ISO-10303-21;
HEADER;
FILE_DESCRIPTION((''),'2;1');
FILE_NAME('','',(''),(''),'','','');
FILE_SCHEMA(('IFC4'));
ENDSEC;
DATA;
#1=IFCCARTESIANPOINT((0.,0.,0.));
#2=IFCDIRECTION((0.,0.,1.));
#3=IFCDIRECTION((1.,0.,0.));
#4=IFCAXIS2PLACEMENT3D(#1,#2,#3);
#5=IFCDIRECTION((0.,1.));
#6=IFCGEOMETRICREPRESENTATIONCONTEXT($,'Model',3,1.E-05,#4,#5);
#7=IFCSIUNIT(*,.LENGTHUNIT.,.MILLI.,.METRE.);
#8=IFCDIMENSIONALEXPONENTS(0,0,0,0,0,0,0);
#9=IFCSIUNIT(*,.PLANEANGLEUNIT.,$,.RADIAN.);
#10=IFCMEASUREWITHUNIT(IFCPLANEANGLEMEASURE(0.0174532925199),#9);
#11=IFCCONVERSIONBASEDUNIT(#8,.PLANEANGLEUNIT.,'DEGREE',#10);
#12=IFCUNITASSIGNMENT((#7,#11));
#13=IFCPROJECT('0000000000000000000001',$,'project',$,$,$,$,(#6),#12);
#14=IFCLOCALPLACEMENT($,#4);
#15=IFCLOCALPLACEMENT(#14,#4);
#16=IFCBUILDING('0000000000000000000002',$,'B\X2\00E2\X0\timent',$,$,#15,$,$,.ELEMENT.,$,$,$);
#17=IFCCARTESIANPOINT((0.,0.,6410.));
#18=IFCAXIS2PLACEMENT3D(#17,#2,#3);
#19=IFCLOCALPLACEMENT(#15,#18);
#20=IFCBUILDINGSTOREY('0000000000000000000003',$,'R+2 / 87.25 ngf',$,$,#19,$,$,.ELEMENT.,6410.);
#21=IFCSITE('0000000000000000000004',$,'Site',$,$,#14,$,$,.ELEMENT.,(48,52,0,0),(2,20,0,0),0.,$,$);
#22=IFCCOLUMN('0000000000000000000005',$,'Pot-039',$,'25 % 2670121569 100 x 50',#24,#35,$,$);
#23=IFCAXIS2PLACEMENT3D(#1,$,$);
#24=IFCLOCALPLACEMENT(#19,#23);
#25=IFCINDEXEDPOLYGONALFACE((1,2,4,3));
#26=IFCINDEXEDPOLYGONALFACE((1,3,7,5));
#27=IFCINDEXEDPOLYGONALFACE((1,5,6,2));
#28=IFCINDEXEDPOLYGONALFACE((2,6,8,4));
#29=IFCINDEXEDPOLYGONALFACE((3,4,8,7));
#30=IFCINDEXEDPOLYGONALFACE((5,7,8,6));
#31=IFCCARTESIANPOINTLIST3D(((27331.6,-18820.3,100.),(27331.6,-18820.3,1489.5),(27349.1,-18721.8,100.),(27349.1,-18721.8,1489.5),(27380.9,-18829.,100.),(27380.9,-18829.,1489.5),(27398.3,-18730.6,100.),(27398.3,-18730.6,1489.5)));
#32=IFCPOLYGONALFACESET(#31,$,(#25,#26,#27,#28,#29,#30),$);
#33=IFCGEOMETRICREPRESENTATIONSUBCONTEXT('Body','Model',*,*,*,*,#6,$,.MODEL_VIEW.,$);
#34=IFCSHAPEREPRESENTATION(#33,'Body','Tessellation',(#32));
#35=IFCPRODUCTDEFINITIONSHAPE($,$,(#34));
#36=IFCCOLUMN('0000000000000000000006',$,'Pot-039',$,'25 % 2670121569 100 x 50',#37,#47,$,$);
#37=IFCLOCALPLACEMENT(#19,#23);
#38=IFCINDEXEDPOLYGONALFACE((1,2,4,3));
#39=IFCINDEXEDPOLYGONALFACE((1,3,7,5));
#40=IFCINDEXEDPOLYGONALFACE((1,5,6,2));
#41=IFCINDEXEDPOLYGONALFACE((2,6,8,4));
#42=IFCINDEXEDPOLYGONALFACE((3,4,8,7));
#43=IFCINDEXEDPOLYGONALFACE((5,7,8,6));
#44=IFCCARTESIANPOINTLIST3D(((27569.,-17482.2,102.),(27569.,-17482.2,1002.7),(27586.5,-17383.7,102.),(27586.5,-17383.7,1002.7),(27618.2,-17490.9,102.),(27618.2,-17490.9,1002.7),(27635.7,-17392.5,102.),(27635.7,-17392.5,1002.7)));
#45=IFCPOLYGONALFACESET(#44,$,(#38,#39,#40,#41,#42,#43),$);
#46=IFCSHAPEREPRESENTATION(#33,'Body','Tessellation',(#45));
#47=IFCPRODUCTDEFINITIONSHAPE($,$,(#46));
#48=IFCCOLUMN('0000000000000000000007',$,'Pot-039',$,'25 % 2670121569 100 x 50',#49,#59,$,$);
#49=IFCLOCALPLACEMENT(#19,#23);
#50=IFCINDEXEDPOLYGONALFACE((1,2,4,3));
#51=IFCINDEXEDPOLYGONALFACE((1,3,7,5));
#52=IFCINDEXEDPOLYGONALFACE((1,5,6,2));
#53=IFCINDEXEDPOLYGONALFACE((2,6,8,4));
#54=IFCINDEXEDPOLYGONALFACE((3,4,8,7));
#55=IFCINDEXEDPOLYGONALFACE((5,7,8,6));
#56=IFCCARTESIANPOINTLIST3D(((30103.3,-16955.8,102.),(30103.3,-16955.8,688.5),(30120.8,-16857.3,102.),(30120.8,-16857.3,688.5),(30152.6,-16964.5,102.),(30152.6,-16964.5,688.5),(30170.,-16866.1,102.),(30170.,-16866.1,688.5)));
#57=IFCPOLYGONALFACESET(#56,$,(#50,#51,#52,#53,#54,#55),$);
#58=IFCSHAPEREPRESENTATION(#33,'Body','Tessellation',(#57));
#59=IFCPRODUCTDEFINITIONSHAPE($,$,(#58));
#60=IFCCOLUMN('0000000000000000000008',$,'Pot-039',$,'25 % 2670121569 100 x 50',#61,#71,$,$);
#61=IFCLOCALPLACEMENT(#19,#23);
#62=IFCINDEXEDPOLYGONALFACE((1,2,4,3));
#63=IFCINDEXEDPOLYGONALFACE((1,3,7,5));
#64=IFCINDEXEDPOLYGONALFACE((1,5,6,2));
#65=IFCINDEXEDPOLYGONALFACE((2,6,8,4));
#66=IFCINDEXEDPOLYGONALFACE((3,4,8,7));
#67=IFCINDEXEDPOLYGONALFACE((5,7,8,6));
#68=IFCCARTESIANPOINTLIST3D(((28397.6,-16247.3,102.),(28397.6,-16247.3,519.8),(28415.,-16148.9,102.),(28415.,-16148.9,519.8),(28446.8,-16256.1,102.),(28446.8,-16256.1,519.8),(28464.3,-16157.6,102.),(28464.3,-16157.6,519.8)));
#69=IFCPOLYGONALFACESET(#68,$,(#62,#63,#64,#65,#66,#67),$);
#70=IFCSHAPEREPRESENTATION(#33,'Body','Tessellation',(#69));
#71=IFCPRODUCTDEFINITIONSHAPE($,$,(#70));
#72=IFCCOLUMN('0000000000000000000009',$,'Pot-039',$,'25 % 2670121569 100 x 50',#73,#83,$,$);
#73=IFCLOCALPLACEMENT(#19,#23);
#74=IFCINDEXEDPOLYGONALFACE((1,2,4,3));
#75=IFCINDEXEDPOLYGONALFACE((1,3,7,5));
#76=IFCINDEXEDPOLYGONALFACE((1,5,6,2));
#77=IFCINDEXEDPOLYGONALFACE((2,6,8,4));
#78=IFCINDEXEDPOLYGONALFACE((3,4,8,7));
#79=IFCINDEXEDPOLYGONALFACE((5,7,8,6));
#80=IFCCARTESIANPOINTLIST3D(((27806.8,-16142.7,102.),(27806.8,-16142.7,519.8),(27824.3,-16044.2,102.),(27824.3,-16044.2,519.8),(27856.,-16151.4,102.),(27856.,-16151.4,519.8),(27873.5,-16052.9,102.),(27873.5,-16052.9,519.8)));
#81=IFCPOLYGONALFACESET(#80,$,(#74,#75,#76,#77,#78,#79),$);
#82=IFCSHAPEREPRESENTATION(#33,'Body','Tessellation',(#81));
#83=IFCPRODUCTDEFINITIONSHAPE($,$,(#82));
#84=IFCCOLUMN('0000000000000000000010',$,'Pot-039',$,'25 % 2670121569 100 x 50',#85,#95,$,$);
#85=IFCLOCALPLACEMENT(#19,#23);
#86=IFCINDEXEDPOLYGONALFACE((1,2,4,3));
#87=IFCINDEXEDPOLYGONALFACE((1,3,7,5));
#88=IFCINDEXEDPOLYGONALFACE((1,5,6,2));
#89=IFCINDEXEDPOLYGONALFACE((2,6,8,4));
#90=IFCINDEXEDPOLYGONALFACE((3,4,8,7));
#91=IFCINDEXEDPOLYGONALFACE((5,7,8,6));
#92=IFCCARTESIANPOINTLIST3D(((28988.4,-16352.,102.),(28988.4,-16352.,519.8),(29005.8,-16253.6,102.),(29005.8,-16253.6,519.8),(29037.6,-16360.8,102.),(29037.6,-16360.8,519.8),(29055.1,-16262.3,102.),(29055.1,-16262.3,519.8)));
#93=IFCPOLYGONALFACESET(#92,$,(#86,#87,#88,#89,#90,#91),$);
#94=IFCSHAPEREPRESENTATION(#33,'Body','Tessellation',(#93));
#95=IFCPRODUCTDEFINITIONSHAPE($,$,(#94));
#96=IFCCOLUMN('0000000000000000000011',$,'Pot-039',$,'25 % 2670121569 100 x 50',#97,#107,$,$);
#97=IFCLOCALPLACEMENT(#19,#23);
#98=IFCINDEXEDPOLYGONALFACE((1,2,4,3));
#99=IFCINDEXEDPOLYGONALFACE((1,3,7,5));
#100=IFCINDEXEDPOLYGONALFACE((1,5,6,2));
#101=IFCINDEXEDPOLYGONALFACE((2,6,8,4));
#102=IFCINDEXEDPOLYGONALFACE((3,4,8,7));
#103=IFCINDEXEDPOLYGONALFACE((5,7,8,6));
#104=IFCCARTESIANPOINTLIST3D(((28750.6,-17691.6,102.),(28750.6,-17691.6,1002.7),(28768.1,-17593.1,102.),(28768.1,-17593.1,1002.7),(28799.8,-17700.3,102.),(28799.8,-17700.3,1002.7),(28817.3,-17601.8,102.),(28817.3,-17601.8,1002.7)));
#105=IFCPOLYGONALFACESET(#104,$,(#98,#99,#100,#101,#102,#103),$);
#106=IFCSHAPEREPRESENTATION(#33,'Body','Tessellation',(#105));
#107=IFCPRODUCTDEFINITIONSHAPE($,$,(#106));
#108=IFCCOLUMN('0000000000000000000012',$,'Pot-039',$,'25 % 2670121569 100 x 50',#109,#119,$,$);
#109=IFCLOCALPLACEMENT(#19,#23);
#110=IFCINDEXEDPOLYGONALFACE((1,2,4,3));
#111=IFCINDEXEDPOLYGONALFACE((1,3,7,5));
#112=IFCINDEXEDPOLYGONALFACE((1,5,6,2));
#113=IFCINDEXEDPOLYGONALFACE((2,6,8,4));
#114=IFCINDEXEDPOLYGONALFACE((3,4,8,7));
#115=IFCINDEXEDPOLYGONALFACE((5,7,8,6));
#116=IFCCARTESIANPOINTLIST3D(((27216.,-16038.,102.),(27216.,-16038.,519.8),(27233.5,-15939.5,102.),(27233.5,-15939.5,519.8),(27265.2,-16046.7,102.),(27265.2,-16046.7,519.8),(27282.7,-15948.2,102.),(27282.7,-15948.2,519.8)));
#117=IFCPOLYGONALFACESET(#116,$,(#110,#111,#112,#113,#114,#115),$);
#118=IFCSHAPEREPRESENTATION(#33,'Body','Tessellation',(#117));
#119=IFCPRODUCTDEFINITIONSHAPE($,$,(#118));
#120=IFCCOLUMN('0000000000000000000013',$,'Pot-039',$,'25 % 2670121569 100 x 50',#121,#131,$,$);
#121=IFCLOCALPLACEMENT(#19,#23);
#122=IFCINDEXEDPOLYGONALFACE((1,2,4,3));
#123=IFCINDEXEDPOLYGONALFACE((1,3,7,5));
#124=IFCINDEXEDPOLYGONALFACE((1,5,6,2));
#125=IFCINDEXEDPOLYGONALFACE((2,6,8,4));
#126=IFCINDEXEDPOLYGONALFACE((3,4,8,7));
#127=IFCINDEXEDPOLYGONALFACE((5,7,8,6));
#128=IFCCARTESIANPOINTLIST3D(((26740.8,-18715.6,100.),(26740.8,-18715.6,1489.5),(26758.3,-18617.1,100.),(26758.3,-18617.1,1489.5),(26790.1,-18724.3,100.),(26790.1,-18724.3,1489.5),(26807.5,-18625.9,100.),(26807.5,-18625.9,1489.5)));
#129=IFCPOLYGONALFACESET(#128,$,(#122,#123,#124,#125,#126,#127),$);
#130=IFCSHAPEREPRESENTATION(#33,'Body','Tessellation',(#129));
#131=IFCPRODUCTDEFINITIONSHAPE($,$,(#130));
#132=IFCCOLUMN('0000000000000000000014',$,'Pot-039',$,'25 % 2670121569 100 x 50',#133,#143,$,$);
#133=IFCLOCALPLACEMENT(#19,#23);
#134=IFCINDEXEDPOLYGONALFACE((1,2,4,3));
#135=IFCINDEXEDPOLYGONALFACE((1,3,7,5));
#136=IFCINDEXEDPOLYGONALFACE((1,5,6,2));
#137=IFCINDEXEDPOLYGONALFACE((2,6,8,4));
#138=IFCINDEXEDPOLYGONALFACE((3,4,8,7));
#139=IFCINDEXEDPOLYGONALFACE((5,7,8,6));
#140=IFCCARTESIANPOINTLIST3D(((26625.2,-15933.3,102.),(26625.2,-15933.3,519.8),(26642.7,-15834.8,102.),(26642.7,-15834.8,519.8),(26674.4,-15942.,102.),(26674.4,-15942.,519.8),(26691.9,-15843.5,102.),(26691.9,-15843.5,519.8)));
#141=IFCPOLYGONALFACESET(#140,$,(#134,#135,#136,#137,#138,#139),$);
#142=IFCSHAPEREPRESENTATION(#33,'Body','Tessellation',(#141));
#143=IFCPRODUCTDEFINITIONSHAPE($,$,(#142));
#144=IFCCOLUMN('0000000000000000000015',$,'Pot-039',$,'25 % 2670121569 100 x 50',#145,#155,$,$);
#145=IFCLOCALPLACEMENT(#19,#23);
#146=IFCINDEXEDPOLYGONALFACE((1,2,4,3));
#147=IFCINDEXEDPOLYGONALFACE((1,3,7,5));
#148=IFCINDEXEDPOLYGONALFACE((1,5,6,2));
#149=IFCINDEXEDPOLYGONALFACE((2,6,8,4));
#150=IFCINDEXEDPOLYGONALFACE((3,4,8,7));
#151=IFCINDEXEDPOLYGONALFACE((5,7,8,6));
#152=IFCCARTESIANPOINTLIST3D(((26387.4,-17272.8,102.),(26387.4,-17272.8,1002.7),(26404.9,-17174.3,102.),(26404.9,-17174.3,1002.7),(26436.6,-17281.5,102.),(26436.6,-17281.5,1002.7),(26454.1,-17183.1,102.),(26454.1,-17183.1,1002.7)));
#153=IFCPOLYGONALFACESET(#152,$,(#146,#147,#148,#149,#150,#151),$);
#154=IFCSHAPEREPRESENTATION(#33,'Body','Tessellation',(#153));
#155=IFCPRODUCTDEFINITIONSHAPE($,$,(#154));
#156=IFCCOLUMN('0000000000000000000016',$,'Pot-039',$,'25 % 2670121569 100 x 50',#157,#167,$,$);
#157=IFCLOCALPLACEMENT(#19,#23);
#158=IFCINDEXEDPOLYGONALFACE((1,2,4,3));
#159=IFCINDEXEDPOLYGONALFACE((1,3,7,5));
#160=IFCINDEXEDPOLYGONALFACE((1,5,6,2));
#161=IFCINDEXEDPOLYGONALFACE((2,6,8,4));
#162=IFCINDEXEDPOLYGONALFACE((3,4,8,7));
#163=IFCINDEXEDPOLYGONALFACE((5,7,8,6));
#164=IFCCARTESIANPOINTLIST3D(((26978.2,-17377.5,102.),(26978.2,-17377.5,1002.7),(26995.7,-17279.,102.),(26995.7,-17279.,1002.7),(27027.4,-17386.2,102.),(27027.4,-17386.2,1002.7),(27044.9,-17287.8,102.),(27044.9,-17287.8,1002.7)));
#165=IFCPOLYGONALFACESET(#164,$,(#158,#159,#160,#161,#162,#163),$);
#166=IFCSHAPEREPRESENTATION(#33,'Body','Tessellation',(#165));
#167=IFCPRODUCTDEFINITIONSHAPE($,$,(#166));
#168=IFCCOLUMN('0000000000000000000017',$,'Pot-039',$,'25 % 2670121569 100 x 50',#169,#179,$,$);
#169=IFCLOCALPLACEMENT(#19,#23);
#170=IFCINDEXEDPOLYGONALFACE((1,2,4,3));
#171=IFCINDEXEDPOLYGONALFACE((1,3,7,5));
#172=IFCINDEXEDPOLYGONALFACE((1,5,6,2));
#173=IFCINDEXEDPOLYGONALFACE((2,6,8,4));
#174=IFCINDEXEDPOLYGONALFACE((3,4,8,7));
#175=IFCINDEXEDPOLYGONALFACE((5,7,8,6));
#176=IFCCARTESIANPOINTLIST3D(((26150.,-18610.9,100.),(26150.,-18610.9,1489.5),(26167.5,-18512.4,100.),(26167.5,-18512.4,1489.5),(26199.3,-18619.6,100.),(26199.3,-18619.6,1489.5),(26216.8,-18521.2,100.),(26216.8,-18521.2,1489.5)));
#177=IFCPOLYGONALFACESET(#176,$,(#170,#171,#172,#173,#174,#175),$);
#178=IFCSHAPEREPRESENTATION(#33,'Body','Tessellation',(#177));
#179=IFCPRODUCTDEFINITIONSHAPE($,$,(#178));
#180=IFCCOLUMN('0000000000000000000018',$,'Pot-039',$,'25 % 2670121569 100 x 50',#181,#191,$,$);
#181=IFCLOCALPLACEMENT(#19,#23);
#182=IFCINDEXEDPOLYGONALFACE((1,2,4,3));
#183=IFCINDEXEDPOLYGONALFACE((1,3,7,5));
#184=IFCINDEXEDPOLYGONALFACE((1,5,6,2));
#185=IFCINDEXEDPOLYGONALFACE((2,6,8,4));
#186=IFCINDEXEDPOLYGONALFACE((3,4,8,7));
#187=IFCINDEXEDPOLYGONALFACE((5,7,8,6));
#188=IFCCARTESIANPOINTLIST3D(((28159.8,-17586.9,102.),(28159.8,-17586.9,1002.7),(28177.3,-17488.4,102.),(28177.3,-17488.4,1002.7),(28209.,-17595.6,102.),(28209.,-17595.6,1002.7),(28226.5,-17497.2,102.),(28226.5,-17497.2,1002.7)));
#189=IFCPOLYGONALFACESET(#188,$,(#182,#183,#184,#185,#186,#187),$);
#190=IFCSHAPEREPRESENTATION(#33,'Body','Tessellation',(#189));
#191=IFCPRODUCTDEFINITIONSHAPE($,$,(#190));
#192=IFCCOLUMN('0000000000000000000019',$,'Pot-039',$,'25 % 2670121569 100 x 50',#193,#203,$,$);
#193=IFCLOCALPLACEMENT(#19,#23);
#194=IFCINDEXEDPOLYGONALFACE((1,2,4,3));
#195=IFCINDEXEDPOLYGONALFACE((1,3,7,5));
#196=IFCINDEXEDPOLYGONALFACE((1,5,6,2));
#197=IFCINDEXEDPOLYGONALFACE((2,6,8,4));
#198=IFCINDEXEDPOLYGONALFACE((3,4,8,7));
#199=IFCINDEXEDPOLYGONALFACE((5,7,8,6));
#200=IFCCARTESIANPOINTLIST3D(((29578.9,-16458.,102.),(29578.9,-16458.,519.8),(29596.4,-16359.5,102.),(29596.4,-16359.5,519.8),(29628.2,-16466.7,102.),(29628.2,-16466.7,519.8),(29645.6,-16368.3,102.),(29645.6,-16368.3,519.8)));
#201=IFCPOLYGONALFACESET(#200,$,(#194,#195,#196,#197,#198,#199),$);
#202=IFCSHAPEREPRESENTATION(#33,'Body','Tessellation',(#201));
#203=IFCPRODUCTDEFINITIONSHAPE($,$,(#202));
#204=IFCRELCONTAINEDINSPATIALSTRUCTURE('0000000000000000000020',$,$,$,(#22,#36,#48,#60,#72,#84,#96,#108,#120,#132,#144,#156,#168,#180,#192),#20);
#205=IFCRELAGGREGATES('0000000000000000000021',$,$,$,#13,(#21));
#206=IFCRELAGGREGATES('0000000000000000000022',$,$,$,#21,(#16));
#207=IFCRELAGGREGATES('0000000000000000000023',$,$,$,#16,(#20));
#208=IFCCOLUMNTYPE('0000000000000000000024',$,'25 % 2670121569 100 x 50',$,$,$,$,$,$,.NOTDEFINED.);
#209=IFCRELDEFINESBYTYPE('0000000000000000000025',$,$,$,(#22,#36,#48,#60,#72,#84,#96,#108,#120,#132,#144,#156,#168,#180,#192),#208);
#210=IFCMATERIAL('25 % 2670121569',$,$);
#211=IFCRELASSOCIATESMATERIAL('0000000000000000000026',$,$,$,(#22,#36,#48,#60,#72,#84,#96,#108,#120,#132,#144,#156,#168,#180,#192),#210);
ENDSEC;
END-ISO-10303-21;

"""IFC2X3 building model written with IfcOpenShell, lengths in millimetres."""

from ifc_helpers import new_model, entity, si_unit, converted_unit, direction, frame, origin_with_axes, origin_2d_with_axis, place, context, subcontext, project, spatial, rectangle, extrude, material, type_object, element, save


model = new_model("IFC2X3")

# Units and contexts
model_context = context("Model", 3, precision=1e-05, world=origin_with_axes(), true_north=direction((0.0, 1.0)))
body_context = subcontext(model_context, "Body", "Model", "MODEL_VIEW")
ifc_project = project(units=[si_unit("LENGTHUNIT", "METRE", prefix="MILLI"), converted_unit("PLANEANGLEUNIT", "DEGREE", entity("IfcPlaneAngleMeasure", 0.0174532925199), si_unit("PLANEANGLEUNIT", "RADIAN"), dimensions=[0, 0, 0, 0, 0, 0, 0])], contexts=[model_context])

# Site, building, storey
site_placement = place(None, origin_with_axes())
site = spatial("IfcSite", under=ifc_project, at=site_placement, Name="Site", CompositionType="ELEMENT", RefLatitude=(48, 52, 0, 0), RefLongitude=(2, 20, 0, 0), RefElevation=0.0)
building_placement = place(site_placement, origin_with_axes())
building = spatial("IfcBuilding", under=site, at=building_placement, Name="Bâtiment", CompositionType="ELEMENT")
storey_placement = place(building_placement, frame((0.0, 0.0, 6410.0), z_axis=(0.0, 0.0, 1.0), x_axis=(1.0, 0.0, 0.0)))
storey = spatial("IfcBuildingStorey", under=building, at=storey_placement, Name="R+2 / 87.25 ngf", CompositionType="ELEMENT", Elevation=6410.0)

# Columns
ifc_material_1 = material(Name="25 % 2670121569")
column_type = type_object("IfcColumnType", Name="25 % 2670121569 100 x 50", PredefinedType="NOTDEFINED")
column_1_placement = place(storey_placement, frame((27365.0, -18775.4, 100.0), z_axis=(0.0, 0.0, 1.0), x_axis=(0.17478, 0.984607, 0.0)))
element("IfcColumn", 1, at=column_1_placement, inside=storey, type_object=column_type, material=ifc_material_1, Name="Pot-039", ObjectType="25 % 2670121569 100 x 50", context=body_context, shape_type="SweptSolid", body=[
    extrude(rectangle(XDim=100.0, YDim=50.0, at=origin_2d_with_axis()), origin_with_axes(), (0.0, 0.0, 1.0), 1389.5),
])
column_2_placement = place(storey_placement, frame((27602.4, -17437.3, 102.0), z_axis=(0.0, 0.0, 1.0), x_axis=(0.17478, 0.984607, 0.0)))
element("IfcColumn", 2, at=column_2_placement, inside=storey, type_object=column_type, material=ifc_material_1, Name="Pot-039", ObjectType="25 % 2670121569 100 x 50", context=body_context, shape_type="SweptSolid", body=[
    extrude(rectangle(XDim=100.0, YDim=50.0, at=origin_2d_with_axis()), origin_with_axes(), (0.0, 0.0, 1.0), 900.7),
])
column_3_placement = place(storey_placement, frame((30136.7, -16910.9, 102.0), z_axis=(0.0, 0.0, 1.0), x_axis=(0.17478, 0.984607, 0.0)))
element("IfcColumn", 3, at=column_3_placement, inside=storey, type_object=column_type, material=ifc_material_1, Name="Pot-039", ObjectType="25 % 2670121569 100 x 50", context=body_context, shape_type="SweptSolid", body=[
    extrude(rectangle(XDim=100.0, YDim=50.0, at=origin_2d_with_axis()), origin_with_axes(), (0.0, 0.0, 1.0), 586.5),
])
for number, where, z_axis, x_axis, name in (
    (4, (28430.9, -16202.5, 102.0), (0.0, 0.0, 1.0), (0.17478, 0.984607, 0.0), "Pot-039"),
    (5, (27840.1, -16097.8, 102.0), (0.0, 0.0, 1.0), (0.17478, 0.984607, 0.0), "Pot-039"),
    (6, (29021.7, -16307.2, 102.0), (0.0, 0.0, 1.0), (0.17478, 0.984607, 0.0), "Pot-039"),
):
    element("IfcColumn", number, at=place(storey_placement, frame(where, z_axis=z_axis, x_axis=x_axis)), inside=storey, type_object=column_type, material=ifc_material_1, Name=name, ObjectType="25 % 2670121569 100 x 50", context=body_context, shape_type="SweptSolid", body=[
        extrude(rectangle(XDim=100.0, YDim=50.0, at=origin_2d_with_axis()), origin_with_axes(), (0.0, 0.0, 1.0), 417.8),
    ])
column_4_placement = place(storey_placement, frame((28784.0, -17646.7, 102.0), z_axis=(0.0, 0.0, 1.0), x_axis=(0.17478, 0.984607, 0.0)))
element("IfcColumn", 7, at=column_4_placement, inside=storey, type_object=column_type, material=ifc_material_1, Name="Pot-039", ObjectType="25 % 2670121569 100 x 50", context=body_context, shape_type="SweptSolid", body=[
    extrude(rectangle(XDim=100.0, YDim=50.0, at=origin_2d_with_axis()), origin_with_axes(), (0.0, 0.0, 1.0), 900.7),
])
column_5_placement = place(storey_placement, frame((27249.3, -15993.1, 102.0), z_axis=(0.0, 0.0, 1.0), x_axis=(0.17478, 0.984607, 0.0)))
element("IfcColumn", 8, at=column_5_placement, inside=storey, type_object=column_type, material=ifc_material_1, Name="Pot-039", ObjectType="25 % 2670121569 100 x 50", context=body_context, shape_type="SweptSolid", body=[
    extrude(rectangle(XDim=100.0, YDim=50.0, at=origin_2d_with_axis()), origin_with_axes(), (0.0, 0.0, 1.0), 417.8),
])
column_6_placement = place(storey_placement, frame((26774.2, -18670.7, 100.0), z_axis=(0.0, 0.0, 1.0), x_axis=(0.17478, 0.984607, 0.0)))
element("IfcColumn", 9, at=column_6_placement, inside=storey, type_object=column_type, material=ifc_material_1, Name="Pot-039", ObjectType="25 % 2670121569 100 x 50", context=body_context, shape_type="SweptSolid", body=[
    extrude(rectangle(XDim=100.0, YDim=50.0, at=origin_2d_with_axis()), origin_with_axes(), (0.0, 0.0, 1.0), 1389.5),
])
column_7_placement = place(storey_placement, frame((26658.5, -15888.4, 102.0), z_axis=(0.0, 0.0, 1.0), x_axis=(0.17478, 0.984607, 0.0)))
element("IfcColumn", 10, at=column_7_placement, inside=storey, type_object=column_type, material=ifc_material_1, Name="Pot-039", ObjectType="25 % 2670121569 100 x 50", context=body_context, shape_type="SweptSolid", body=[
    extrude(rectangle(XDim=100.0, YDim=50.0, at=origin_2d_with_axis()), origin_with_axes(), (0.0, 0.0, 1.0), 417.8),
])
for number, where, z_axis, x_axis, name in (
    (11, (26420.8, -17227.9, 102.0), (0.0, 0.0, 1.0), (0.17478, 0.984607, 0.0), "Pot-039"),
    (12, (27011.6, -17332.6, 102.0), (0.0, 0.0, 1.0), (0.17478, 0.984607, 0.0), "Pot-039"),
):
    element("IfcColumn", number, at=place(storey_placement, frame(where, z_axis=z_axis, x_axis=x_axis)), inside=storey, type_object=column_type, material=ifc_material_1, Name=name, ObjectType="25 % 2670121569 100 x 50", context=body_context, shape_type="SweptSolid", body=[
        extrude(rectangle(XDim=100.0, YDim=50.0, at=origin_2d_with_axis()), origin_with_axes(), (0.0, 0.0, 1.0), 900.7),
    ])
column_8_placement = place(storey_placement, frame((26183.4, -18566.0, 100.0), z_axis=(0.0, 0.0, 1.0), x_axis=(0.17478, 0.984607, 0.0)))
element("IfcColumn", 13, at=column_8_placement, inside=storey, type_object=column_type, material=ifc_material_1, Name="Pot-039", ObjectType="25 % 2670121569 100 x 50", context=body_context, shape_type="SweptSolid", body=[
    extrude(rectangle(XDim=100.0, YDim=50.0, at=origin_2d_with_axis()), origin_with_axes(), (0.0, 0.0, 1.0), 1389.5),
])
column_9_placement = place(storey_placement, frame((28193.2, -17542.0, 102.0), z_axis=(0.0, 0.0, 1.0), x_axis=(0.17478, 0.984607, 0.0)))
element("IfcColumn", 14, at=column_9_placement, inside=storey, type_object=column_type, material=ifc_material_1, Name="Pot-039", ObjectType="25 % 2670121569 100 x 50", context=body_context, shape_type="SweptSolid", body=[
    extrude(rectangle(XDim=100.0, YDim=50.0, at=origin_2d_with_axis()), origin_with_axes(), (0.0, 0.0, 1.0), 900.7),
])
column_10_placement = place(storey_placement, frame((29612.3, -16413.1, 102.0), z_axis=(0.0, 0.0, 1.0), x_axis=(0.17478, 0.984607, 0.0)))
element("IfcColumn", 15, at=column_10_placement, inside=storey, type_object=column_type, material=ifc_material_1, Name="Pot-039", ObjectType="25 % 2670121569 100 x 50", context=body_context, shape_type="SweptSolid", body=[
    extrude(rectangle(XDim=100.0, YDim=50.0, at=origin_2d_with_axis()), origin_with_axes(), (0.0, 0.0, 1.0), 417.8),
])

save(model, "model.ifc")
